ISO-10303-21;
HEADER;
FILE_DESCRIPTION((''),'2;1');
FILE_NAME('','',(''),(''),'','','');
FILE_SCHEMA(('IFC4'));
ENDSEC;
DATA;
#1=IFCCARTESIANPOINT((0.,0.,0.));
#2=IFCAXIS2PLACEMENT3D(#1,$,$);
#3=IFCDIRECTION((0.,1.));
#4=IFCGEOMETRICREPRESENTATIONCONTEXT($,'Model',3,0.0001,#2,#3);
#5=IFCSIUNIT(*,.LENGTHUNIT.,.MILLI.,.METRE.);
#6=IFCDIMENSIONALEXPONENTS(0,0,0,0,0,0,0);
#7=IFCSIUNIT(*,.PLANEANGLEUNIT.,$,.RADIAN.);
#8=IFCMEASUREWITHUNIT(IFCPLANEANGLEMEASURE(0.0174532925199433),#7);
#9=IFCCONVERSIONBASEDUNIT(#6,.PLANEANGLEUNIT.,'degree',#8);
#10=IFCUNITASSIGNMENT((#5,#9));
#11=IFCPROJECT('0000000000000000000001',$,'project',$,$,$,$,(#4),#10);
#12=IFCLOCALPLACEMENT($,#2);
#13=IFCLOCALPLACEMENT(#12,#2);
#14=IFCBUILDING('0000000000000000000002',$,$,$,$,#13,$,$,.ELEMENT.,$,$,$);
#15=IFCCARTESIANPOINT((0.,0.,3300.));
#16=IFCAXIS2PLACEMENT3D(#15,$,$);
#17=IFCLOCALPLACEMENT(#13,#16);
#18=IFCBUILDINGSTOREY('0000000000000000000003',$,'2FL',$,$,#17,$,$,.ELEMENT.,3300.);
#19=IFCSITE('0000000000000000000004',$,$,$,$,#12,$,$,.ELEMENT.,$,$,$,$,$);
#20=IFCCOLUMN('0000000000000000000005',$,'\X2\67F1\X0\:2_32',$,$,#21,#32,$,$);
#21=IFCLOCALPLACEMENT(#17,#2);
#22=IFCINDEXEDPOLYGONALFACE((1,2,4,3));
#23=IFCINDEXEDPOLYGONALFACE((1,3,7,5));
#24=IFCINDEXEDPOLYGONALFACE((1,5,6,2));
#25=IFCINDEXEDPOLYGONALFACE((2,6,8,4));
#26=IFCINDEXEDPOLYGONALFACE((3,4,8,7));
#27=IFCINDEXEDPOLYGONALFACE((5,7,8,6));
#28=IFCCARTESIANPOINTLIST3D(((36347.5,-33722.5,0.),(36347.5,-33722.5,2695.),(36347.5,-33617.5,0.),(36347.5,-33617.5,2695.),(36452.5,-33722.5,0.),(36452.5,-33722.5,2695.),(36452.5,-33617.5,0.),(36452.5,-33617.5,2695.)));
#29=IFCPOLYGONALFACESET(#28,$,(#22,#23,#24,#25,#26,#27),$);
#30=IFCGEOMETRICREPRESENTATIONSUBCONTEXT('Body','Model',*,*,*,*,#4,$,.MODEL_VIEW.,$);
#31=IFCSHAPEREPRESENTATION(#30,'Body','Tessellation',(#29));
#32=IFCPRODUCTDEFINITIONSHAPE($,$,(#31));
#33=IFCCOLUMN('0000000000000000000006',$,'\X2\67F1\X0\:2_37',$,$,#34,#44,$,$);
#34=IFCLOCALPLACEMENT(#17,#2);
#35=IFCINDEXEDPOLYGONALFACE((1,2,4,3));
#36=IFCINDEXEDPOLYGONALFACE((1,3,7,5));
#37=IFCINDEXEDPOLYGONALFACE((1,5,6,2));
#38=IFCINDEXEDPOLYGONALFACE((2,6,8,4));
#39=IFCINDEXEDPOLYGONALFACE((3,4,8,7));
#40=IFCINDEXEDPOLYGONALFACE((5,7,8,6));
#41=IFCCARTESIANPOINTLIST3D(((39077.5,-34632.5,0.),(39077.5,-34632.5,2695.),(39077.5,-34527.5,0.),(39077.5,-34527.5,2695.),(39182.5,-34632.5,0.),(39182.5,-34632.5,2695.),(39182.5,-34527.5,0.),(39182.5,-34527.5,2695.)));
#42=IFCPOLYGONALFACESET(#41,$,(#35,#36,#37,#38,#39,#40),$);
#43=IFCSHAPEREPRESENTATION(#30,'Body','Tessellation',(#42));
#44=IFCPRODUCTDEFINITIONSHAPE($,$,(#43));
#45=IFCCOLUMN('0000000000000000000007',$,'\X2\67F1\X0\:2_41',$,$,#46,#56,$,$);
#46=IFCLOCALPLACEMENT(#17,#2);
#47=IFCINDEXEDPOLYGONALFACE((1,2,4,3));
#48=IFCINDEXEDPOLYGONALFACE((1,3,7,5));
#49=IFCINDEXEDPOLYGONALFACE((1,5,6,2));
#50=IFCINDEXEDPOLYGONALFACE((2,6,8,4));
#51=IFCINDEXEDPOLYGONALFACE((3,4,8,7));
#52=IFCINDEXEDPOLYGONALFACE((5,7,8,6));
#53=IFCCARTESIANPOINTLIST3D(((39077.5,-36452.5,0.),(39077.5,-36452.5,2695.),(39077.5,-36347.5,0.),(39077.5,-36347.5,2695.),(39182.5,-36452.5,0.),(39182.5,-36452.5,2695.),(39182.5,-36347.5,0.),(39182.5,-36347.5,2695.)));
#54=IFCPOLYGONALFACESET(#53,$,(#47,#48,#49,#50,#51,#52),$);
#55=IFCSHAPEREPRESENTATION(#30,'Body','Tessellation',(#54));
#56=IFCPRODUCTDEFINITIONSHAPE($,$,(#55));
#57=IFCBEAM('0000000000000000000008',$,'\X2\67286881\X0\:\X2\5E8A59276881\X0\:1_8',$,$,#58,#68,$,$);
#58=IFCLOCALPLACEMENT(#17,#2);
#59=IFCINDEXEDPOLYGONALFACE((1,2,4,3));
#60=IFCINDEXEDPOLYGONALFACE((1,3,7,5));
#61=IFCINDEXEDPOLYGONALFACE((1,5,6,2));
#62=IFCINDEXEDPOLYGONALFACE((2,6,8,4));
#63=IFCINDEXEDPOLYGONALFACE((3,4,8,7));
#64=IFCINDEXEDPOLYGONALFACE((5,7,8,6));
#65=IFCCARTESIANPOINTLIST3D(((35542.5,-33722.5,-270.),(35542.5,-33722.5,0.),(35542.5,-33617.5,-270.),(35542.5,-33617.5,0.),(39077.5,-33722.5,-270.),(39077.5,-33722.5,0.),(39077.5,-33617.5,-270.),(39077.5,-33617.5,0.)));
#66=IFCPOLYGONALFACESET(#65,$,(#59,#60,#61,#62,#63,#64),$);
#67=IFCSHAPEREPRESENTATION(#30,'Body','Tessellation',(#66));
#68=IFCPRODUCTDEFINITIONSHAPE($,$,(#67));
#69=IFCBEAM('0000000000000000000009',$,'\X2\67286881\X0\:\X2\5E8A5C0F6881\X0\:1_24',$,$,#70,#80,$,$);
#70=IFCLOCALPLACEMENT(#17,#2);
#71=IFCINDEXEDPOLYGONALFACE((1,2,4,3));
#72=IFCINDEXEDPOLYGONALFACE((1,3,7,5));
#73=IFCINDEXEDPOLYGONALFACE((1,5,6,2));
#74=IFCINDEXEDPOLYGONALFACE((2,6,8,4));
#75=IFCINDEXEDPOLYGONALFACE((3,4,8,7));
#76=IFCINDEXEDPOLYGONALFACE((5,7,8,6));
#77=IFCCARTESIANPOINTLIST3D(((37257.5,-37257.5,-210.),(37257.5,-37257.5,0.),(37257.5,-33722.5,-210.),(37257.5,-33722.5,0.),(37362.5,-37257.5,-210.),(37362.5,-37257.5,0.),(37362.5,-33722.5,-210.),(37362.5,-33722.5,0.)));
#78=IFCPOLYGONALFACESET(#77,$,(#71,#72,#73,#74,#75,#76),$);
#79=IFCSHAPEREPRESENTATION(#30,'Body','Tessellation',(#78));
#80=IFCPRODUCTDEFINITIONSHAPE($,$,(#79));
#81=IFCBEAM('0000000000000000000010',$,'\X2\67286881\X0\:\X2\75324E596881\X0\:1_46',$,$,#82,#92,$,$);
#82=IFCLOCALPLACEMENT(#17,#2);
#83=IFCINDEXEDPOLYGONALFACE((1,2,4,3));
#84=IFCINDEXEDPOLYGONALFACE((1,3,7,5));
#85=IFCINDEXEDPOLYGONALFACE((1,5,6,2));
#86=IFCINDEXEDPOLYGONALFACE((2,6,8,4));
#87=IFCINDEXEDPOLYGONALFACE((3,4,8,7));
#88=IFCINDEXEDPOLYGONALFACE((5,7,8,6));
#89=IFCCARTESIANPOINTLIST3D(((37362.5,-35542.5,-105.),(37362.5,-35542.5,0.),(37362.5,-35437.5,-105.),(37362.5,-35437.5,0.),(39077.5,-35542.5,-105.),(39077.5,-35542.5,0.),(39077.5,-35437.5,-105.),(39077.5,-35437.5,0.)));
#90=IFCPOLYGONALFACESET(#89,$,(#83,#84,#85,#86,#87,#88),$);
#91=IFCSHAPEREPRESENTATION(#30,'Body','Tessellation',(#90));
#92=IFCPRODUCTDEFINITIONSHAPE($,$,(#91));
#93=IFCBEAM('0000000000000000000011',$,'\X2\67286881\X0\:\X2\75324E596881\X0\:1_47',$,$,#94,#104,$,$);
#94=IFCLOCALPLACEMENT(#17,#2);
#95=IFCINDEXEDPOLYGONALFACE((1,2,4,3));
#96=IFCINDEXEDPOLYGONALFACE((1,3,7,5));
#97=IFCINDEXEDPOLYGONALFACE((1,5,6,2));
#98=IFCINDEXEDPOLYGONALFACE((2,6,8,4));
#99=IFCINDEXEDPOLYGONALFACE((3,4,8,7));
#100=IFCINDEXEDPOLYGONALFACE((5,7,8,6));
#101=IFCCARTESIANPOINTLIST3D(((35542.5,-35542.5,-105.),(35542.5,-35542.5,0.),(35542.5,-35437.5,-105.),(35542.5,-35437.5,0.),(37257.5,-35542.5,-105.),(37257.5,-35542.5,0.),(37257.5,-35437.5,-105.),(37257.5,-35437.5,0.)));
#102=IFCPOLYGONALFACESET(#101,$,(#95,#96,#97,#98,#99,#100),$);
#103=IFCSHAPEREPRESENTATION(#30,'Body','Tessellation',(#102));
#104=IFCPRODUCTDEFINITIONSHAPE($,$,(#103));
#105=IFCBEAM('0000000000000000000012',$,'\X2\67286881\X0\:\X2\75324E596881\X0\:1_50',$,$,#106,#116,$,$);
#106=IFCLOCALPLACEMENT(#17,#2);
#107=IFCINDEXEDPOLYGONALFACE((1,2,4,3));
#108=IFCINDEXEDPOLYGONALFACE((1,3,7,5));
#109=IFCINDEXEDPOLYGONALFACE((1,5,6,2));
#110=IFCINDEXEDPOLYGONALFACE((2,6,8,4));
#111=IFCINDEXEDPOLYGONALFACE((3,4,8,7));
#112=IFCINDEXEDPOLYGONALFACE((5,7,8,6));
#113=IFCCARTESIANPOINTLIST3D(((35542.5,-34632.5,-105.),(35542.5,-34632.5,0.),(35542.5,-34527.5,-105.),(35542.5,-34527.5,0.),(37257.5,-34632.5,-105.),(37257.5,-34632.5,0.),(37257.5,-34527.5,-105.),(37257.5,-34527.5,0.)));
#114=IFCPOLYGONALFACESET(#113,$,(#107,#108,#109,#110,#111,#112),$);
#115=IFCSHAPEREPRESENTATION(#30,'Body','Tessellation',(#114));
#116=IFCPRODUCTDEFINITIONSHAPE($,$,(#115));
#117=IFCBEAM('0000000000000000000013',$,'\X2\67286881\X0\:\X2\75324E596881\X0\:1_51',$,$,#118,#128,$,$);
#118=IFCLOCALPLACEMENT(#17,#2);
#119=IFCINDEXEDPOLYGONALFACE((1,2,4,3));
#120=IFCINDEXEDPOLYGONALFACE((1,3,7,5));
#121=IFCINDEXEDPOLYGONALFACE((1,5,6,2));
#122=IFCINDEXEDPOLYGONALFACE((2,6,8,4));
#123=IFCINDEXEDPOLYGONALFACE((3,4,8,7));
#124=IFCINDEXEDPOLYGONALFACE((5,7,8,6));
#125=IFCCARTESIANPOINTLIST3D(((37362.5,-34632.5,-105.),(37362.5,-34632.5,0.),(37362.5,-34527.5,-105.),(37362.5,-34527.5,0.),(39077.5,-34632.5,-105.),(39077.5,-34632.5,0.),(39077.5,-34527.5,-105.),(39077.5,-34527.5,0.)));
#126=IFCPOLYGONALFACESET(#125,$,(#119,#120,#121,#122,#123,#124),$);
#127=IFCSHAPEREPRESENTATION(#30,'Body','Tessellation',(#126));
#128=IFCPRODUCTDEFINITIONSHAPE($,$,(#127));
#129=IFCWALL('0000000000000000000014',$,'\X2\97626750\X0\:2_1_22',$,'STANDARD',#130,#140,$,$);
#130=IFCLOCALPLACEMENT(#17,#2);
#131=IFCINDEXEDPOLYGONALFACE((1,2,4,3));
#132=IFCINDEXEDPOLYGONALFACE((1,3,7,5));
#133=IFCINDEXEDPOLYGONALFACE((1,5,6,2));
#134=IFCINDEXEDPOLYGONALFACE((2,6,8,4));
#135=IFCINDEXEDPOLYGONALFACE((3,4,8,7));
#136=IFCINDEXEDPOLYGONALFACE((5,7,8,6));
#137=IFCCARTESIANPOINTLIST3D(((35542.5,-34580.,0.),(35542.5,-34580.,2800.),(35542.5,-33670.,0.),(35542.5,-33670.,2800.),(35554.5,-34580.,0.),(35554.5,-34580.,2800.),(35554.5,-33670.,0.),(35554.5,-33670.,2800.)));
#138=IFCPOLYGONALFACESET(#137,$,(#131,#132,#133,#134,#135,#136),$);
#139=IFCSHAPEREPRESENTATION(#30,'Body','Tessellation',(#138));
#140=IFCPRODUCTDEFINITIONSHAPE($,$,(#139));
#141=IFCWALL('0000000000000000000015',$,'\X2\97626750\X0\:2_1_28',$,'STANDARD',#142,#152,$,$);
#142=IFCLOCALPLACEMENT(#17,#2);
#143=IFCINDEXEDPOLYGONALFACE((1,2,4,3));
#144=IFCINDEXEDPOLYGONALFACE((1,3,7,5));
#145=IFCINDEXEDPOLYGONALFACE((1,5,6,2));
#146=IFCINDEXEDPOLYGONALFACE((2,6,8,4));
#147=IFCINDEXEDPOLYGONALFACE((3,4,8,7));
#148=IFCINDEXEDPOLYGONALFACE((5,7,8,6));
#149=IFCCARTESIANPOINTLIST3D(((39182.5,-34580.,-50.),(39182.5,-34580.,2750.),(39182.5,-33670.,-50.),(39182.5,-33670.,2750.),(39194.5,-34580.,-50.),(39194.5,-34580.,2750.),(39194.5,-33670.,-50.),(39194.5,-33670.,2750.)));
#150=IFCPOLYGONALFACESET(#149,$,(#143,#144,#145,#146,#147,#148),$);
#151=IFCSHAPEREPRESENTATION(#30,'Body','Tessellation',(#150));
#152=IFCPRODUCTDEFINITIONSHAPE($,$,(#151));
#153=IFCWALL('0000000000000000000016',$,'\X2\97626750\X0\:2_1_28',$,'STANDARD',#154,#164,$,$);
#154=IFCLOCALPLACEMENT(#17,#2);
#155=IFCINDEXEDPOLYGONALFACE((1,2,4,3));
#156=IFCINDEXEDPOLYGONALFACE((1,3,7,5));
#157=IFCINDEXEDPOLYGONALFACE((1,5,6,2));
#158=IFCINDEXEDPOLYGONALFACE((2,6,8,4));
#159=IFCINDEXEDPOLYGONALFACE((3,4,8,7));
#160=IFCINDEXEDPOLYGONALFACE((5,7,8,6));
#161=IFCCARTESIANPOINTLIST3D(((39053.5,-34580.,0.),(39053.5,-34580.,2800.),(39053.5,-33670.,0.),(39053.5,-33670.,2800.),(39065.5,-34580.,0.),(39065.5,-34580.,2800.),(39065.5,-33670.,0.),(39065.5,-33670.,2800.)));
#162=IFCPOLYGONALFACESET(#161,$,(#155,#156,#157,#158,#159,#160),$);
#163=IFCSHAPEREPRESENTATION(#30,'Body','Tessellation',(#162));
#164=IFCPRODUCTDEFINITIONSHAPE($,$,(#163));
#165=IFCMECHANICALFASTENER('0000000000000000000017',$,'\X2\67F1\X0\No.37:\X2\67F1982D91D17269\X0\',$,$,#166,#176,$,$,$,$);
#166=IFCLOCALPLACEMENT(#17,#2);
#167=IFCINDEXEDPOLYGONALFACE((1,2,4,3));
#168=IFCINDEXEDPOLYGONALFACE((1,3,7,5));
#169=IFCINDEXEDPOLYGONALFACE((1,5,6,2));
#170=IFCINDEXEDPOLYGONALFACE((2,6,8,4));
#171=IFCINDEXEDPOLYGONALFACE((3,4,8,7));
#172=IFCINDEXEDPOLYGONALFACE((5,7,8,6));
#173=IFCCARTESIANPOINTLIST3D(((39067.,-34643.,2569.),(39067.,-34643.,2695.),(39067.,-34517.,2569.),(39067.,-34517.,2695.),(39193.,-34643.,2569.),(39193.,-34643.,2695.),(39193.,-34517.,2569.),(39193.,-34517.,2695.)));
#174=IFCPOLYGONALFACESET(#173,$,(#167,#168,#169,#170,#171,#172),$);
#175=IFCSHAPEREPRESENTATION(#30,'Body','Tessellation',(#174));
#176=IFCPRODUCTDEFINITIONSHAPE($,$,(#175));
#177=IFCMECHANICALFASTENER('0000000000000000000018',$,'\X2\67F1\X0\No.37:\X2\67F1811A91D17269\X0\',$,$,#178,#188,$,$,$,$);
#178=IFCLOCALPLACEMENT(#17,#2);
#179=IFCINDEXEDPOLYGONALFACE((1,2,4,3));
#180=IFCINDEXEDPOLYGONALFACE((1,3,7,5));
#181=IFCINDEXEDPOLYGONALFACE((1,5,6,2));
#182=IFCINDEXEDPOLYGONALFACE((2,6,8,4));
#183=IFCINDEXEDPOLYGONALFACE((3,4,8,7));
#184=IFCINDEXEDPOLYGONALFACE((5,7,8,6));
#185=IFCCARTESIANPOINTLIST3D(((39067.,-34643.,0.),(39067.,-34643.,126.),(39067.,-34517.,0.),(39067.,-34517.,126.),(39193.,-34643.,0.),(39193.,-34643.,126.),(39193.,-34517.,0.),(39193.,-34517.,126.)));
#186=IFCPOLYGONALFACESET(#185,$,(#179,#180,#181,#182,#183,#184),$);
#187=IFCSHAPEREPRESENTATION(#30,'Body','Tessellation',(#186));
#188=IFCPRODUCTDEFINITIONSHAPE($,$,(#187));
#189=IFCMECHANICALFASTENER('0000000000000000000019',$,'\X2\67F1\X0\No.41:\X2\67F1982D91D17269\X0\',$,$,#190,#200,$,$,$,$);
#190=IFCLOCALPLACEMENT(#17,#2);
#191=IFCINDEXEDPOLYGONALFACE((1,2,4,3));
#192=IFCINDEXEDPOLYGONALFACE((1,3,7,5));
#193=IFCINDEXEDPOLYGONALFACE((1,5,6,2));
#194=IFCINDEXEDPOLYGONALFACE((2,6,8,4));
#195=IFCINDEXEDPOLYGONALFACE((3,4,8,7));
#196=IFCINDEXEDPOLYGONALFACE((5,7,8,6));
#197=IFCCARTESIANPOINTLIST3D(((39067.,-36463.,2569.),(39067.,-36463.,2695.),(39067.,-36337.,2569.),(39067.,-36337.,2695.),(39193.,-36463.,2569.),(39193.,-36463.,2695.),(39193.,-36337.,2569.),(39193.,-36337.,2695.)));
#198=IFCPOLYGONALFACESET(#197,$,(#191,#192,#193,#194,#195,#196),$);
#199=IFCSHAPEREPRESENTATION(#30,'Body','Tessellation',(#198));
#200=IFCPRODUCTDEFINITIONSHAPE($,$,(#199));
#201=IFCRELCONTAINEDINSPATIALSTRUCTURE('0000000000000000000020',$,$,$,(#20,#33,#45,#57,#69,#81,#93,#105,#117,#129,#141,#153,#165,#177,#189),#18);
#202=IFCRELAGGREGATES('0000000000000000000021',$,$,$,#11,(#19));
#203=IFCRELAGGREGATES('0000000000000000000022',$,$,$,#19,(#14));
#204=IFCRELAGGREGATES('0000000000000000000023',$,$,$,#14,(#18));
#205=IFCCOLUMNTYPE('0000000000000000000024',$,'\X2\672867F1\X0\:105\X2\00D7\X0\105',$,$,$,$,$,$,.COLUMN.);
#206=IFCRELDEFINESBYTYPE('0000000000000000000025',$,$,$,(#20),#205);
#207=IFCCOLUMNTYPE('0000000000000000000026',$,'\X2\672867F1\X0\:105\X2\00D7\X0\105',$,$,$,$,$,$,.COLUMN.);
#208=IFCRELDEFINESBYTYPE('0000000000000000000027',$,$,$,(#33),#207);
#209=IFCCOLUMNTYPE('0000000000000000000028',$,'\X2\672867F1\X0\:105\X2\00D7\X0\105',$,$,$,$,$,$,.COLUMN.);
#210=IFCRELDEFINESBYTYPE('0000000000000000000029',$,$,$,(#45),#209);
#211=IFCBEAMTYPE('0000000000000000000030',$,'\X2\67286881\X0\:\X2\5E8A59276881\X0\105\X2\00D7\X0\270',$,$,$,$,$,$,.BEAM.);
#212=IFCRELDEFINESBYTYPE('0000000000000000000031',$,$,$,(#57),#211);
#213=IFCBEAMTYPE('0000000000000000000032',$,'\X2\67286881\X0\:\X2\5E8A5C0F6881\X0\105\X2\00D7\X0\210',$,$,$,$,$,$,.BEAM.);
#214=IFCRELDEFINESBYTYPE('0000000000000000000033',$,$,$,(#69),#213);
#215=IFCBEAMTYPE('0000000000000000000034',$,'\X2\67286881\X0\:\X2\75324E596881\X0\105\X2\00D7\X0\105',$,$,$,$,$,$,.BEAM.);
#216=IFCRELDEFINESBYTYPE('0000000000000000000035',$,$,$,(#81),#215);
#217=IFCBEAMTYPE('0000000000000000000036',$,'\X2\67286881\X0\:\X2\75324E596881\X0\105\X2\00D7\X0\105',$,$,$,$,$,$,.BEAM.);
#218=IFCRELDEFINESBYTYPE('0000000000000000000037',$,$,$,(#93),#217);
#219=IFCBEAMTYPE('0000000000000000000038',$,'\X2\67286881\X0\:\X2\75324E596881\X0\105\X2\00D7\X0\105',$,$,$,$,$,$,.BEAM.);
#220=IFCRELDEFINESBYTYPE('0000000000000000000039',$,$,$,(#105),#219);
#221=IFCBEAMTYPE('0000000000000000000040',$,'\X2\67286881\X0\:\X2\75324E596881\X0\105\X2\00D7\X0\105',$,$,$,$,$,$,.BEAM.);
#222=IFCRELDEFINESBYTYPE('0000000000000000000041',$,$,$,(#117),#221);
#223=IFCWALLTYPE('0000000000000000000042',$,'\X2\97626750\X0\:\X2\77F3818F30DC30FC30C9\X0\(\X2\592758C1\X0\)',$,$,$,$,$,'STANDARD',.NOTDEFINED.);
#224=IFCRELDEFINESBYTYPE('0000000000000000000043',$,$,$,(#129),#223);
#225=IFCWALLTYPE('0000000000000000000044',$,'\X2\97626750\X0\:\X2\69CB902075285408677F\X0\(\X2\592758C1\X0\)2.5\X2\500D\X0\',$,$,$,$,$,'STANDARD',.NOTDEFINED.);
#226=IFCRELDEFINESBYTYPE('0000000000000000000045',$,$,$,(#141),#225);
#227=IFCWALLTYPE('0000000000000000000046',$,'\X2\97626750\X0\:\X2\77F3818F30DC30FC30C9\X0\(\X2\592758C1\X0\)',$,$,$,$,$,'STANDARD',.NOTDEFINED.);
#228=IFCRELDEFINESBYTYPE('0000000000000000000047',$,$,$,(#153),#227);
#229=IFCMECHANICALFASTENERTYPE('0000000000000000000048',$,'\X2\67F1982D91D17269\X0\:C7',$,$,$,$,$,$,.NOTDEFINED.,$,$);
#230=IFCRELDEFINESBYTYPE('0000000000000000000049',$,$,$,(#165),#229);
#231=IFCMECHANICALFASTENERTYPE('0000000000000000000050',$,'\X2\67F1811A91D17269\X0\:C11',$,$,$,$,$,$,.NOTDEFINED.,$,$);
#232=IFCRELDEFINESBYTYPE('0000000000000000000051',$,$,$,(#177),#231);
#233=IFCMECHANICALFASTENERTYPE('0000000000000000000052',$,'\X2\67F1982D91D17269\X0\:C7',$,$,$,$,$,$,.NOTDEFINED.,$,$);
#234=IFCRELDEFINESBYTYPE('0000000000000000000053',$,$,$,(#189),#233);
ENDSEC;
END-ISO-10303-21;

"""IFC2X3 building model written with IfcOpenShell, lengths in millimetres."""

from ifc_helpers import new_model, entity, si_unit, converted_unit, direction, frame, origin, origin_with_axes, origin_2d, place, context, subcontext, project, spatial, polyline, rectangle, outline, extrude, type_object, element, save


model = new_model("IFC2X3")

# Units and contexts
model_context = context("Model", 3, precision=0.0001, world=origin(), true_north=direction((0.0, 1.0)))
body_context = subcontext(model_context, "Body", "Model", "MODEL_VIEW")
ifc_project = project(units=[si_unit("LENGTHUNIT", "METRE", prefix="MILLI"), converted_unit("PLANEANGLEUNIT", "degree", entity("IfcPlaneAngleMeasure", 0.0174532925199433), si_unit("PLANEANGLEUNIT", "RADIAN"), dimensions=[0, 0, 0, 0, 0, 0, 0])], contexts=[model_context])

# Site, building, storey
site_placement = place(None, origin())
site = spatial("IfcSite", under=ifc_project, at=site_placement, CompositionType="ELEMENT")
building_placement = place(site_placement, origin())
building = spatial("IfcBuilding", under=site, at=building_placement, CompositionType="ELEMENT")
storey_placement = place(building_placement, frame((0.0, 0.0, 3300.0)))
storey = spatial("IfcBuildingStorey", under=building, at=storey_placement, Name="2FL", CompositionType="ELEMENT", Elevation=3300.0)

# Columns
column_type_1 = type_object("IfcColumnType", Name="木柱:105×105", PredefinedType="COLUMN")
column_1_placement = place(storey_placement, frame((36400.0, -33670.0, 0.0)))
element("IfcColumn", 1, at=column_1_placement, inside=storey, type_object=column_type_1, Name="柱:2_32", context=body_context, shape_type="SweptSolid", body=[
    extrude(rectangle(XDim=105.0, YDim=105.0, at=origin_2d()), origin_with_axes(), (0.0, 0.0, 1.0), 2695.0),
])
column_type_2 = type_object("IfcColumnType", Name="木柱:105×105", PredefinedType="COLUMN")
column_2_placement = place(storey_placement, frame((39130.0, -34580.0, 0.0)))
element("IfcColumn", 2, at=column_2_placement, inside=storey, type_object=column_type_2, Name="柱:2_37", context=body_context, shape_type="SweptSolid", body=[
    extrude(rectangle(XDim=105.0, YDim=105.0, at=origin_2d()), origin_with_axes(), (0.0, 0.0, 1.0), 2695.0),
])
column_type_3 = type_object("IfcColumnType", Name="木柱:105×105", PredefinedType="COLUMN")
column_3_placement = place(storey_placement, frame((39130.0, -36400.0, 0.0)))
element("IfcColumn", 3, at=column_3_placement, inside=storey, type_object=column_type_3, Name="柱:2_41", context=body_context, shape_type="SweptSolid", body=[
    extrude(rectangle(XDim=105.0, YDim=105.0, at=origin_2d()), origin_with_axes(), (0.0, 0.0, 1.0), 2695.0),
])

# Beams
beam_type_1 = type_object("IfcBeamType", Name="木梁:床大梁105×270", PredefinedType="BEAM")
beam_1_placement = place(storey_placement, frame((35542.5, -33670.0, -135.0), z_axis=(1.0, 0.0, 0.0), x_axis=(0.0, 1.0, 0.0)))
element("IfcBeam", 4, at=beam_1_placement, inside=storey, type_object=beam_type_1, Name="木梁:床大梁:1_8", context=body_context, shape_type="SweptSolid", body=[
    extrude(rectangle(XDim=105.0, YDim=270.0, at=origin_2d()), origin_with_axes(), (0.0, 0.0, 1.0), 3535.0),
])
beam_type_2 = type_object("IfcBeamType", Name="木梁:床小梁105×210", PredefinedType="BEAM")
beam_2_placement = place(storey_placement, frame((37310.0, -33722.5, -105.0), z_axis=(0.0, -1.0, 0.0), x_axis=(1.0, 0.0, 0.0)))
element("IfcBeam", 5, at=beam_2_placement, inside=storey, type_object=beam_type_2, Name="木梁:床小梁:1_24", context=body_context, shape_type="SweptSolid", body=[
    extrude(rectangle(XDim=105.0, YDim=210.0, at=origin_2d()), origin_with_axes(), (0.0, 0.0, 1.0), 3535.0),
])
beam_type_3 = type_object("IfcBeamType", Name="木梁:甲乙梁105×105", PredefinedType="BEAM")
beam_3_placement = place(storey_placement, frame((37362.5, -35490.0, -52.5), z_axis=(1.0, 0.0, 0.0), x_axis=(0.0, 1.0, 0.0)))
element("IfcBeam", 6, at=beam_3_placement, inside=storey, type_object=beam_type_3, Name="木梁:甲乙梁:1_46", context=body_context, shape_type="SweptSolid", body=[
    extrude(rectangle(XDim=105.0, YDim=105.0, at=origin_2d()), origin_with_axes(), (0.0, 0.0, 1.0), 1715.0),
])
beam_type_4 = type_object("IfcBeamType", Name="木梁:甲乙梁105×105", PredefinedType="BEAM")
beam_4_placement = place(storey_placement, frame((35542.5, -35490.0, -52.5), z_axis=(1.0, 0.0, 0.0), x_axis=(0.0, 1.0, 0.0)))
element("IfcBeam", 7, at=beam_4_placement, inside=storey, type_object=beam_type_4, Name="木梁:甲乙梁:1_47", context=body_context, shape_type="SweptSolid", body=[
    extrude(rectangle(XDim=105.0, YDim=105.0, at=origin_2d()), origin_with_axes(), (0.0, 0.0, 1.0), 1715.0),
])
beam_type_5 = type_object("IfcBeamType", Name="木梁:甲乙梁105×105", PredefinedType="BEAM")
beam_5_placement = place(storey_placement, frame((35542.5, -34580.0, -52.5), z_axis=(1.0, 0.0, 0.0), x_axis=(0.0, 1.0, 0.0)))
element("IfcBeam", 8, at=beam_5_placement, inside=storey, type_object=beam_type_5, Name="木梁:甲乙梁:1_50", context=body_context, shape_type="SweptSolid", body=[
    extrude(rectangle(XDim=105.0, YDim=105.0, at=origin_2d()), origin_with_axes(), (0.0, 0.0, 1.0), 1715.0),
])
beam_type_6 = type_object("IfcBeamType", Name="木梁:甲乙梁105×105", PredefinedType="BEAM")
beam_6_placement = place(storey_placement, frame((37362.5, -34580.0, -52.5), z_axis=(1.0, 0.0, 0.0), x_axis=(0.0, 1.0, 0.0)))
element("IfcBeam", 9, at=beam_6_placement, inside=storey, type_object=beam_type_6, Name="木梁:甲乙梁:1_51", context=body_context, shape_type="SweptSolid", body=[
    extrude(rectangle(XDim=105.0, YDim=105.0, at=origin_2d()), origin_with_axes(), (0.0, 0.0, 1.0), 1715.0),
])

# Walls
wall_type_1 = type_object("IfcWallType", Name="面材:石膏ボード(大壁)", ElementType="STANDARD", PredefinedType="NOTDEFINED")
wall_1_placement = place(storey_placement, frame((35554.5, -34125.0, 0.0), z_axis=(-1.0, 0.0, 0.0), x_axis=(0.0, -1.0, 0.0)))
element("IfcWall", 10, at=wall_1_placement, inside=storey, type_object=wall_type_1, Name="面材:2_1_22", ObjectType="STANDARD", context=body_context, shape_type="SweptSolid", body=[
    extrude(outline(polyline([(455.0, 0.0, 0.0), (-455.0, 0.0, 0.0), (-455.0, 2800.0, 0.0), (455.0, 2800.0, 0.0), (455.0, 0.0, 0.0)])), origin_with_axes(), (0.0, 0.0, 1.0), 12.0),
])
wall_type_2 = type_object("IfcWallType", Name="面材:構造用合板(大壁)2.5倍", ElementType="STANDARD", PredefinedType="NOTDEFINED")
wall_2_placement = place(storey_placement, frame((39194.5, -34125.0, -50.0), z_axis=(-1.0, 0.0, 0.0), x_axis=(0.0, -1.0, 0.0)))
element("IfcWall", 11, at=wall_2_placement, inside=storey, type_object=wall_type_2, Name="面材:2_1_28", ObjectType="STANDARD", context=body_context, shape_type="SweptSolid", body=[
    extrude(outline(polyline([(455.0, 0.0, 0.0), (-455.0, 0.0, 0.0), (-455.0, 2800.0, 0.0), (455.0, 2800.0, 0.0), (455.0, 0.0, 0.0)])), origin_with_axes(), (0.0, 0.0, 1.0), 12.0),
])
wall_type_3 = type_object("IfcWallType", Name="面材:石膏ボード(大壁)", ElementType="STANDARD", PredefinedType="NOTDEFINED")
wall_3_placement = place(storey_placement, frame((39065.5, -34125.0, 0.0), z_axis=(-1.0, 0.0, 0.0), x_axis=(0.0, -1.0, 0.0)))
element("IfcWall", 12, at=wall_3_placement, inside=storey, type_object=wall_type_3, Name="面材:2_1_28", ObjectType="STANDARD", context=body_context, shape_type="SweptSolid", body=[
    extrude(outline(polyline([(455.0, 0.0, 0.0), (-455.0, 0.0, 0.0), (-455.0, 2800.0, 0.0), (455.0, 2800.0, 0.0), (455.0, 0.0, 0.0)])), origin_with_axes(), (0.0, 0.0, 1.0), 12.0),
])

# Mechanical fasteners
mechanical_fastener_type_1 = type_object("IfcMechanicalFastenerType", Name="柱頭金物:C7")
mechanical_fastener_1_placement = place(storey_placement, frame((39130.0, -34580.0, 2569.0)))
element("IfcMechanicalFastener", 13, at=mechanical_fastener_1_placement, inside=storey, type_object=mechanical_fastener_type_1, Name="柱No.37:柱頭金物", context=body_context, shape_type="SweptSolid", body=[
    extrude(rectangle(XDim=126.0, YDim=126.0, at=origin_2d()), origin_with_axes(), (0.0, 0.0, 1.0), 126.0),
])
mechanical_fastener_type_2 = type_object("IfcMechanicalFastenerType", Name="柱脚金物:C11")
mechanical_fastener_2_placement = place(storey_placement, frame((39130.0, -34580.0, 0.0)))
element("IfcMechanicalFastener", 14, at=mechanical_fastener_2_placement, inside=storey, type_object=mechanical_fastener_type_2, Name="柱No.37:柱脚金物", context=body_context, shape_type="SweptSolid", body=[
    extrude(rectangle(XDim=126.0, YDim=126.0, at=origin_2d()), origin_with_axes(), (0.0, 0.0, 1.0), 126.0),
])
mechanical_fastener_type_3 = type_object("IfcMechanicalFastenerType", Name="柱頭金物:C7")
mechanical_fastener_3_placement = place(storey_placement, frame((39130.0, -36400.0, 2569.0)))
element("IfcMechanicalFastener", 15, at=mechanical_fastener_3_placement, inside=storey, type_object=mechanical_fastener_type_3, Name="柱No.41:柱頭金物", context=body_context, shape_type="SweptSolid", body=[
    extrude(rectangle(XDim=126.0, YDim=126.0, at=origin_2d()), origin_with_axes(), (0.0, 0.0, 1.0), 126.0),
])

save(model, "model.ifc")
